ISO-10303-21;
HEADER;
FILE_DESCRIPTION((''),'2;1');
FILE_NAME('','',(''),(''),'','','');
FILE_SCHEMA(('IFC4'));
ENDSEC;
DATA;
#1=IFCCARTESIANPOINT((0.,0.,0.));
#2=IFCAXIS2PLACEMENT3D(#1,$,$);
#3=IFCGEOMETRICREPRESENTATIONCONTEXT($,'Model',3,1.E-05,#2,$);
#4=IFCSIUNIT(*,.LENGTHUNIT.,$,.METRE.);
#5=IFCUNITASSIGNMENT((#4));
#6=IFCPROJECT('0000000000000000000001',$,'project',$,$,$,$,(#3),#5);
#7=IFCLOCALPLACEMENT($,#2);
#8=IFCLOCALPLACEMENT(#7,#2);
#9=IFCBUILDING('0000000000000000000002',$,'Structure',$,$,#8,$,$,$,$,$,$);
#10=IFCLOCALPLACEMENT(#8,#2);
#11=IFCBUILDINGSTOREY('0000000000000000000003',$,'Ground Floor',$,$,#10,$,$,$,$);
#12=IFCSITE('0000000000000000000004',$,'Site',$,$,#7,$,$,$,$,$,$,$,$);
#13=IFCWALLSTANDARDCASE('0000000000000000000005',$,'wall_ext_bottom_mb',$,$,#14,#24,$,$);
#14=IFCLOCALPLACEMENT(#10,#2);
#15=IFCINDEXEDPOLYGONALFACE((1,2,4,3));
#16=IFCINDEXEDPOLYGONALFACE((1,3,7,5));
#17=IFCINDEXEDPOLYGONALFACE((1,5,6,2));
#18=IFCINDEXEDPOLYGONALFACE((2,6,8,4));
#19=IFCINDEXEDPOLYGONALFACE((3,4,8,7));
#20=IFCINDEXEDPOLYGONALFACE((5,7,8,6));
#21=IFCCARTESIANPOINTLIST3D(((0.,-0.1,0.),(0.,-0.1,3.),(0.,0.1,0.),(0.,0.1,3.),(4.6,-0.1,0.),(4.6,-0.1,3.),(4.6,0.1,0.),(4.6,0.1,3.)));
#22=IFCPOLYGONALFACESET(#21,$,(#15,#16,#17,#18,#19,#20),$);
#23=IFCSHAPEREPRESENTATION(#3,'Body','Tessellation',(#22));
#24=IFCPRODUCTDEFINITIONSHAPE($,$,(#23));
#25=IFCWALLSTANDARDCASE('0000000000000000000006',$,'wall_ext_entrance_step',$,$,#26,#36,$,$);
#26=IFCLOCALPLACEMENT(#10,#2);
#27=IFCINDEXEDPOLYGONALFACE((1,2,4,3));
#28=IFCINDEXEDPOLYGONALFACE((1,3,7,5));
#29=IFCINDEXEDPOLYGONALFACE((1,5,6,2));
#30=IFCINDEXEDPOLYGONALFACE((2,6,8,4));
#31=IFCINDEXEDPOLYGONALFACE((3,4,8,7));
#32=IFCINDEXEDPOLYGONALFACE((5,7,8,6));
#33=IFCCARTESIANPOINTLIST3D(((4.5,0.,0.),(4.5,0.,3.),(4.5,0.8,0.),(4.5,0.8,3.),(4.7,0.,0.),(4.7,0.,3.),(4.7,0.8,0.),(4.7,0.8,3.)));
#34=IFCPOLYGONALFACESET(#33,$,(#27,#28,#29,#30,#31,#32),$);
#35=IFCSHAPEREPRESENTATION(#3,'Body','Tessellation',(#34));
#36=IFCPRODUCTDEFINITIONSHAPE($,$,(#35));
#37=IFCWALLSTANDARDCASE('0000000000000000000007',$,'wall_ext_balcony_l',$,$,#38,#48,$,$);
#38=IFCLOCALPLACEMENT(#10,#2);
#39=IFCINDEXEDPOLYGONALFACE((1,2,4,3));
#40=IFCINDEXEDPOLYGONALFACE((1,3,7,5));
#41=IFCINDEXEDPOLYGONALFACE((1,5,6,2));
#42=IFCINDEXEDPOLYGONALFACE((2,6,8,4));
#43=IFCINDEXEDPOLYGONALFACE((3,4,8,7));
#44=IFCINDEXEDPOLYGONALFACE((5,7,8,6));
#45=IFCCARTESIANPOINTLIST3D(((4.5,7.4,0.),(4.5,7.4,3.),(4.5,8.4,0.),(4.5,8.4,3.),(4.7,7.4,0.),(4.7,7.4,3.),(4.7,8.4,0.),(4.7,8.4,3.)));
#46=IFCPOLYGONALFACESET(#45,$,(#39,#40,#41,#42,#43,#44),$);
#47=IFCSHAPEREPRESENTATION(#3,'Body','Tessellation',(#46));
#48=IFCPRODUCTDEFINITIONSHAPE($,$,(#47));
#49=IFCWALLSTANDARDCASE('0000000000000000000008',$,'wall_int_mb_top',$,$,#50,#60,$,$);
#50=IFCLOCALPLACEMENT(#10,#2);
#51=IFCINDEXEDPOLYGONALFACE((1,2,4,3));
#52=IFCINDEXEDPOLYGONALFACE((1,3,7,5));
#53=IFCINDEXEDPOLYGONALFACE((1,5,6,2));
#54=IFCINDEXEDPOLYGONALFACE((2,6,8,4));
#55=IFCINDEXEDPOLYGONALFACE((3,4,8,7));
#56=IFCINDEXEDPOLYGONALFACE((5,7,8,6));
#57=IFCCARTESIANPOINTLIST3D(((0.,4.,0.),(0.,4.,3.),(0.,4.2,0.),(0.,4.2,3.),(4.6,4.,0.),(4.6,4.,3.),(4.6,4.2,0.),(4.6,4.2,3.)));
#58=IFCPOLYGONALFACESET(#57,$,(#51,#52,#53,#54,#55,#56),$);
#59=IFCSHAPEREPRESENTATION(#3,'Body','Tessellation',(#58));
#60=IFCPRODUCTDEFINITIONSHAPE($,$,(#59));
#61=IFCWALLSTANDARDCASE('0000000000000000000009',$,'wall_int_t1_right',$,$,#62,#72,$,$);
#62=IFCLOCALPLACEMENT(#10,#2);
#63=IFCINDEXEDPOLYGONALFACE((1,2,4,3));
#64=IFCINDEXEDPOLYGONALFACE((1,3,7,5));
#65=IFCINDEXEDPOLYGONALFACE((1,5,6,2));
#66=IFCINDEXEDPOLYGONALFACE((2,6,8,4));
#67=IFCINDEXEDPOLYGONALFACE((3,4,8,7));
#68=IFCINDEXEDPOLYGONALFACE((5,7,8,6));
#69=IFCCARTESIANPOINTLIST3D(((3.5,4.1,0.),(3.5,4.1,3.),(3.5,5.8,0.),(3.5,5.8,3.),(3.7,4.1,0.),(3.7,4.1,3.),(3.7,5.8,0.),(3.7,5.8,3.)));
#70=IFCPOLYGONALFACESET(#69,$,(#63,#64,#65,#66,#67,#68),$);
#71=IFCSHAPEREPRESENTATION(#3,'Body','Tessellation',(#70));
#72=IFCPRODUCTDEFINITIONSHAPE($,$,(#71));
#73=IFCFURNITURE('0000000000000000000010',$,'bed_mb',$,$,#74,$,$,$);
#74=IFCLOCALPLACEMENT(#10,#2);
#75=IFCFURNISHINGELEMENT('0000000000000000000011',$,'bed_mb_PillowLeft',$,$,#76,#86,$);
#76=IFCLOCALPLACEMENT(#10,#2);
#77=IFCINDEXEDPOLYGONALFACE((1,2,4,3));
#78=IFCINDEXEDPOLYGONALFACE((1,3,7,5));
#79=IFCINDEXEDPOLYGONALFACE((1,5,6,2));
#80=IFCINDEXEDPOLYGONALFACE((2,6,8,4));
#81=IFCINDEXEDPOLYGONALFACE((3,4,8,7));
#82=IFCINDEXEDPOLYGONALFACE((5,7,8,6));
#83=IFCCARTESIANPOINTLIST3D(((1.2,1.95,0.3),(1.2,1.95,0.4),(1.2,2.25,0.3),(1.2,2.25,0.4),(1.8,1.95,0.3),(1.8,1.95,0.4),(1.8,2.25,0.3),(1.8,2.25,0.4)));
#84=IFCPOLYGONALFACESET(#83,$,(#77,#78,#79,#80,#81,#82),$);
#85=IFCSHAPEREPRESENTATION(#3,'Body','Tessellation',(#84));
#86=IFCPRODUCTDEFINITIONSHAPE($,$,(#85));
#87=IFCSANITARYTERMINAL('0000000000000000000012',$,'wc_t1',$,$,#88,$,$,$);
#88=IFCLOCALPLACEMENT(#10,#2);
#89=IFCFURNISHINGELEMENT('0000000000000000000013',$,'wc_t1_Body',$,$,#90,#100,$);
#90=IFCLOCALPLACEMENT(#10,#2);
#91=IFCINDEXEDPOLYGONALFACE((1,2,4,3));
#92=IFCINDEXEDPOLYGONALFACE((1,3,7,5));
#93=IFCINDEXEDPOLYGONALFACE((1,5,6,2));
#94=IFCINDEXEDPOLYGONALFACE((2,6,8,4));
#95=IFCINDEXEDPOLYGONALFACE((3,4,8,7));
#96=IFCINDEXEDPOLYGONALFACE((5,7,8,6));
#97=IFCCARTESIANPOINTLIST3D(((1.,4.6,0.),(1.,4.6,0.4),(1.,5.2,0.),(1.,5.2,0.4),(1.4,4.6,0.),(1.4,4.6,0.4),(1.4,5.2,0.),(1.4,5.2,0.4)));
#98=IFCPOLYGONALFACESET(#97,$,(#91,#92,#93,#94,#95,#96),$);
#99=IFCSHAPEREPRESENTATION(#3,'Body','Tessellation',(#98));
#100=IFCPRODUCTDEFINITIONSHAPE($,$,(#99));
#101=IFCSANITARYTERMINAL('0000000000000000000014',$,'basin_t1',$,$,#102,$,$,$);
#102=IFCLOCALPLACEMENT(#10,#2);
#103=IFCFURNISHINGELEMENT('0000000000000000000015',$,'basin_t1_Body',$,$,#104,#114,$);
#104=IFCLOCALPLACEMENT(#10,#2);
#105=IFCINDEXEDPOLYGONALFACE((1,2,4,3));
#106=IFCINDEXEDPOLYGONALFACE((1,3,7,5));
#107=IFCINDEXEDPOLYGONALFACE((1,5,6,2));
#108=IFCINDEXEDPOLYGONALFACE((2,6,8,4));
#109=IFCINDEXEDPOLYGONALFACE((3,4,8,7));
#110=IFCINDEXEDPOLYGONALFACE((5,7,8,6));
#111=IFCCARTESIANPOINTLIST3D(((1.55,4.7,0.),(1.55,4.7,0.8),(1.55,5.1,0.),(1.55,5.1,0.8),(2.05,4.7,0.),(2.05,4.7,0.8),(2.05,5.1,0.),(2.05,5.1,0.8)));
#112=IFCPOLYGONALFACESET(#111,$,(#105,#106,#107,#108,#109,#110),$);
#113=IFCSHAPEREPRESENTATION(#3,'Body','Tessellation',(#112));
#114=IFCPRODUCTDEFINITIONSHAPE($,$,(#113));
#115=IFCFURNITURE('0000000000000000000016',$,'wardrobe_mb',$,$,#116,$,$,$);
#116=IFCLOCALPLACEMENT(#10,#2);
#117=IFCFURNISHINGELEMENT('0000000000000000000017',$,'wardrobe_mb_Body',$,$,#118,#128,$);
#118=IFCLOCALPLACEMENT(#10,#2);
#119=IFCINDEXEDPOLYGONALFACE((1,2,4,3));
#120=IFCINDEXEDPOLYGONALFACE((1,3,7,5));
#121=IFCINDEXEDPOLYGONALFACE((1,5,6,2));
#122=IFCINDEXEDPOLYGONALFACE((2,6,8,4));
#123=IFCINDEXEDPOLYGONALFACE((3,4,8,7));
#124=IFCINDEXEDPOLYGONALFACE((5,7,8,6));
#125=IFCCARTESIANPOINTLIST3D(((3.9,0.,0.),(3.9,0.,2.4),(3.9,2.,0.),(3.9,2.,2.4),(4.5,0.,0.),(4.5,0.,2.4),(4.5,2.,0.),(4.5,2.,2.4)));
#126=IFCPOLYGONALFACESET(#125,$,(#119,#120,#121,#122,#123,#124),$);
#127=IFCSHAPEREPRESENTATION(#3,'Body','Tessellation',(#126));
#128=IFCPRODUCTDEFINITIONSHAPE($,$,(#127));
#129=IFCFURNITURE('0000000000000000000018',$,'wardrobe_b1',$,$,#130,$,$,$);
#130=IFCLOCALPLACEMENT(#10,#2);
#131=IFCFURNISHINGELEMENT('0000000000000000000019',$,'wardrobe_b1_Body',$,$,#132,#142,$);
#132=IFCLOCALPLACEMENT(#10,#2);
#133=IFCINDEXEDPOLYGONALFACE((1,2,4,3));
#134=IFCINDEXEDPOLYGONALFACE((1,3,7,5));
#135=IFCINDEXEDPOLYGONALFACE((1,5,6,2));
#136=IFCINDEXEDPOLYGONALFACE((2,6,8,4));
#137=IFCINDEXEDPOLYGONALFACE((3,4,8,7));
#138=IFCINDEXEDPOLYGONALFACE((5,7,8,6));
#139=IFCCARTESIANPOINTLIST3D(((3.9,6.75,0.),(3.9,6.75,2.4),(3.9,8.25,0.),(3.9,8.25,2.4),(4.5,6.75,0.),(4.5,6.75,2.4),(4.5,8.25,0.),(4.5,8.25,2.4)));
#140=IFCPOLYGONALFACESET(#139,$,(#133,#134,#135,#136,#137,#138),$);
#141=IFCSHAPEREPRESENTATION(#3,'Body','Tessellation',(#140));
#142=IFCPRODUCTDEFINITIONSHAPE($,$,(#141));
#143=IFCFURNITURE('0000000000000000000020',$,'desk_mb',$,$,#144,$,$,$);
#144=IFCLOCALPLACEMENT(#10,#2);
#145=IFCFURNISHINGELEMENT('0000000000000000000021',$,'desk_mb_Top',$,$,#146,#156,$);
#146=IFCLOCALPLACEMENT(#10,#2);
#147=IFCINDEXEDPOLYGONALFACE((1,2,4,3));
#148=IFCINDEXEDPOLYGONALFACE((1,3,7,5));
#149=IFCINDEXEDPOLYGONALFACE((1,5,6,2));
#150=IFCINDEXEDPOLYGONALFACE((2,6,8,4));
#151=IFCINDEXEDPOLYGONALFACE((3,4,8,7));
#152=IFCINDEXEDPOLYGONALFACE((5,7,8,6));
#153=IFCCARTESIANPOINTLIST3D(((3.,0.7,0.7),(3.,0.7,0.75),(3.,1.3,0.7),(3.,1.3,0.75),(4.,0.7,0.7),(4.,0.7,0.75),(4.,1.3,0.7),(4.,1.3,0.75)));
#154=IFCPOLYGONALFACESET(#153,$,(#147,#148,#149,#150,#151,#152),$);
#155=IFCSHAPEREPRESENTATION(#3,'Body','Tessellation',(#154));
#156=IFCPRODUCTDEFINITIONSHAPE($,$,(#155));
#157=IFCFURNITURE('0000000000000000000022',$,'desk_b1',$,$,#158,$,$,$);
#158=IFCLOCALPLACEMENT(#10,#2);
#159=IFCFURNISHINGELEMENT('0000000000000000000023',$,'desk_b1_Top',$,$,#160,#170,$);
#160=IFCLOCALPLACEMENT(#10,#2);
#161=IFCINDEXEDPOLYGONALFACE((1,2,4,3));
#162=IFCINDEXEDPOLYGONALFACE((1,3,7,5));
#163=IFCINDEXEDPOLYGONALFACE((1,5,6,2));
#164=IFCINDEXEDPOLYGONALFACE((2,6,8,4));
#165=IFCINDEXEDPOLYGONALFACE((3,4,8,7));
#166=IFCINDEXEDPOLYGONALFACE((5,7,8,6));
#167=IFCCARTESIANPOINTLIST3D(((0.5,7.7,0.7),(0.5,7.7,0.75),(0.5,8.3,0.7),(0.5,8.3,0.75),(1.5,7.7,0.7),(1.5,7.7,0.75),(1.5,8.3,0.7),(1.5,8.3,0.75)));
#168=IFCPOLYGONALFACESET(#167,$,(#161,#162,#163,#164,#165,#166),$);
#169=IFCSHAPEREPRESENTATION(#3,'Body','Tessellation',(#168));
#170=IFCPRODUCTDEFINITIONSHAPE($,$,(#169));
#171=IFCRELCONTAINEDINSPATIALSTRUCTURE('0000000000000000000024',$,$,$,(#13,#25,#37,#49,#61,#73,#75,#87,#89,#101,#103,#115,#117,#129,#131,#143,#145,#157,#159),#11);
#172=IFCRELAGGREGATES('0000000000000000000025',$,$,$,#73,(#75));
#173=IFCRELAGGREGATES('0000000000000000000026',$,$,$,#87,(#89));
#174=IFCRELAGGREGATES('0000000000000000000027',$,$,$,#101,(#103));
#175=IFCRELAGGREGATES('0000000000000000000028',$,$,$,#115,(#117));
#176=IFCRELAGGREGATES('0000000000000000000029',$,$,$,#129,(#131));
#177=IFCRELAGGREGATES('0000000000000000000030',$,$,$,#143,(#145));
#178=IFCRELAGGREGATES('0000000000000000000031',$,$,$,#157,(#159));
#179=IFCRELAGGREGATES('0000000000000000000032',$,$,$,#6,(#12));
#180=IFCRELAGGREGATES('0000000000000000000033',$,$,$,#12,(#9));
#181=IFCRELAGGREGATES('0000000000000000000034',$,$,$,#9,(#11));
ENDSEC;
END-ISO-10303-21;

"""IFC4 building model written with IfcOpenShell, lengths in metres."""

from ifc_helpers import new_model, si_unit, frame, origin, origin_2d, place, context, project, spatial, rectangle, extrude, element, aggregate, save


model = new_model("IFC4")

# Units and contexts
model_context = context("Model", 3, precision=1e-05, world=origin())
ifc_project = project(units=[si_unit("LENGTHUNIT", "METRE")], contexts=[model_context])

# Site, building, storey
site_placement = place(None, origin())
site = spatial("IfcSite", under=ifc_project, at=site_placement, Name="Site")
building_placement = place(site_placement, origin())
building = spatial("IfcBuilding", under=site, at=building_placement, Name="Structure")
storey_placement = place(building_placement, origin())
storey = spatial("IfcBuildingStorey", under=building, at=storey_placement, Name="Ground Floor")

# Walls
wall_1_placement = place(storey_placement, frame((0.0, 0.0, 0.0), x_axis=(1.0, 0.0, 0.0)))
element("IfcWallStandardCase", 1, at=wall_1_placement, inside=storey, Name="wall_ext_bottom_mb", context=model_context, shape_type="SweptSolid", body=[
    extrude(rectangle(XDim=4.6, YDim=0.2, at=origin_2d()), frame((2.3, 0.0, 0.0)), (0.0, 0.0, 1.0), 3.0),
])
wall_2_placement = place(storey_placement, frame((4.6, 0.0, 0.0), x_axis=(0.0, 1.0, 0.0)))
element("IfcWallStandardCase", 2, at=wall_2_placement, inside=storey, Name="wall_ext_entrance_step", context=model_context, shape_type="SweptSolid", body=[
    extrude(rectangle(XDim=0.8, YDim=0.2, at=origin_2d()), frame((0.4, 0.0, 0.0)), (0.0, 0.0, 1.0), 3.0),
])
wall_3_placement = place(storey_placement, frame((4.6, 8.4, 0.0), x_axis=(0.0, -1.0, 0.0)))
element("IfcWallStandardCase", 3, at=wall_3_placement, inside=storey, Name="wall_ext_balcony_l", context=model_context, shape_type="SweptSolid", body=[
    extrude(rectangle(XDim=1.0, YDim=0.2, at=origin_2d()), frame((0.5, 0.0, 0.0)), (0.0, 0.0, 1.0), 3.0),
])
wall_4_placement = place(storey_placement, frame((0.0, 4.1, 0.0), x_axis=(1.0, 0.0, 0.0)))
element("IfcWallStandardCase", 4, at=wall_4_placement, inside=storey, Name="wall_int_mb_top", context=model_context, shape_type="SweptSolid", body=[
    extrude(rectangle(XDim=4.6, YDim=0.2, at=origin_2d()), frame((2.3, 0.0, 0.0)), (0.0, 0.0, 1.0), 3.0),
])
wall_5_placement = place(storey_placement, frame((3.6, 4.1, 0.0), x_axis=(0.0, 1.0, 0.0)))
element("IfcWallStandardCase", 5, at=wall_5_placement, inside=storey, Name="wall_int_t1_right", context=model_context, shape_type="SweptSolid", body=[
    extrude(rectangle(XDim=1.7, YDim=0.2, at=origin_2d()), frame((0.85, 0.0, 0.0)), (0.0, 0.0, 1.0), 3.0),
])

# Furniture, furnishing element
furniture_1_placement = place(storey_placement, frame((2.0, 1.5, 0.0)))
furniture_1 = element("IfcFurniture", 6, at=furniture_1_placement, inside=storey, Name="bed_mb")
furnishing_1_placement = place(furniture_1_placement, origin())
furnishing_1 = element("IfcFurnishingElement", 7, at=furnishing_1_placement, inside=storey, Name="bed_mb_PillowLeft", context=model_context, shape_type="SweptSolid", body=[
    extrude(rectangle(XDim=0.6, YDim=0.3, at=origin_2d()), frame((-0.5, 0.6, 0.3)), (0.0, 0.0, 1.0), 0.1),
])
aggregate(furniture_1, [furnishing_1])

# Sanitary terminals, furnishing elements
sanitary_terminal_1_placement = place(storey_placement, frame((1.2, 4.9, 0.0)))
sanitary_terminal_1 = element("IfcSanitaryTerminal", 8, at=sanitary_terminal_1_placement, inside=storey, Name="wc_t1")
furnishing_2_placement = place(sanitary_terminal_1_placement, origin())
furnishing_2 = element("IfcFurnishingElement", 9, at=furnishing_2_placement, inside=storey, Name="wc_t1_Body", context=model_context, shape_type="SweptSolid", body=[
    extrude(rectangle(XDim=0.4, YDim=0.6, at=origin_2d()), origin(), (0.0, 0.0, 1.0), 0.4),
])
aggregate(sanitary_terminal_1, [furnishing_2])
sanitary_terminal_2_placement = place(storey_placement, frame((1.8, 4.9, 0.0)))
sanitary_terminal_2 = element("IfcSanitaryTerminal", 10, at=sanitary_terminal_2_placement, inside=storey, Name="basin_t1")
furnishing_3_placement = place(sanitary_terminal_2_placement, origin())
furnishing_3 = element("IfcFurnishingElement", 11, at=furnishing_3_placement, inside=storey, Name="basin_t1_Body", context=model_context, shape_type="SweptSolid", body=[
    extrude(rectangle(XDim=0.5, YDim=0.4, at=origin_2d()), origin(), (0.0, 0.0, 1.0), 0.8),
])
aggregate(sanitary_terminal_2, [furnishing_3])

# Furniture, furnishing elements
furniture_2_placement = place(storey_placement, frame((4.2, 1.0, 0.0)))
furniture_2 = element("IfcFurniture", 12, at=furniture_2_placement, inside=storey, Name="wardrobe_mb")
furnishing_4_placement = place(furniture_2_placement, origin())
furnishing_4 = element("IfcFurnishingElement", 13, at=furnishing_4_placement, inside=storey, Name="wardrobe_mb_Body", context=model_context, shape_type="SweptSolid", body=[
    extrude(rectangle(XDim=0.6, YDim=2.0, at=origin_2d()), origin(), (0.0, 0.0, 1.0), 2.4),
])
aggregate(furniture_2, [furnishing_4])
furniture_3_placement = place(storey_placement, frame((4.2, 7.5, 0.0)))
furniture_3 = element("IfcFurniture", 14, at=furniture_3_placement, inside=storey, Name="wardrobe_b1")
furnishing_5_placement = place(furniture_3_placement, origin())
furnishing_5 = element("IfcFurnishingElement", 15, at=furnishing_5_placement, inside=storey, Name="wardrobe_b1_Body", context=model_context, shape_type="SweptSolid", body=[
    extrude(rectangle(XDim=0.6, YDim=1.5, at=origin_2d()), origin(), (0.0, 0.0, 1.0), 2.4),
])
aggregate(furniture_3, [furnishing_5])

# Furniture, furnishing elements
furniture_4_placement = place(storey_placement, frame((3.5, 1.0, 0.0)))
furniture_4 = element("IfcFurniture", 16, at=furniture_4_placement, inside=storey, Name="desk_mb")
furnishing_6_placement = place(furniture_4_placement, origin())
furnishing_6 = element("IfcFurnishingElement", 17, at=furnishing_6_placement, inside=storey, Name="desk_mb_Top", context=model_context, shape_type="SweptSolid", body=[
    extrude(rectangle(XDim=1.0, YDim=0.6, at=origin_2d()), frame((0.0, 0.0, 0.7)), (0.0, 0.0, 1.0), 0.05),
])
aggregate(furniture_4, [furnishing_6])
furniture_5_placement = place(storey_placement, frame((1.0, 8.0, 0.0)))
furniture_5 = element("IfcFurniture", 18, at=furniture_5_placement, inside=storey, Name="desk_b1")
furnishing_7_placement = place(furniture_5_placement, origin())
furnishing_7 = element("IfcFurnishingElement", 19, at=furnishing_7_placement, inside=storey, Name="desk_b1_Top", context=model_context, shape_type="SweptSolid", body=[
    extrude(rectangle(XDim=1.0, YDim=0.6, at=origin_2d()), frame((0.0, 0.0, 0.7)), (0.0, 0.0, 1.0), 0.05),
])
aggregate(furniture_5, [furnishing_7])

save(model, "model.ifc")
